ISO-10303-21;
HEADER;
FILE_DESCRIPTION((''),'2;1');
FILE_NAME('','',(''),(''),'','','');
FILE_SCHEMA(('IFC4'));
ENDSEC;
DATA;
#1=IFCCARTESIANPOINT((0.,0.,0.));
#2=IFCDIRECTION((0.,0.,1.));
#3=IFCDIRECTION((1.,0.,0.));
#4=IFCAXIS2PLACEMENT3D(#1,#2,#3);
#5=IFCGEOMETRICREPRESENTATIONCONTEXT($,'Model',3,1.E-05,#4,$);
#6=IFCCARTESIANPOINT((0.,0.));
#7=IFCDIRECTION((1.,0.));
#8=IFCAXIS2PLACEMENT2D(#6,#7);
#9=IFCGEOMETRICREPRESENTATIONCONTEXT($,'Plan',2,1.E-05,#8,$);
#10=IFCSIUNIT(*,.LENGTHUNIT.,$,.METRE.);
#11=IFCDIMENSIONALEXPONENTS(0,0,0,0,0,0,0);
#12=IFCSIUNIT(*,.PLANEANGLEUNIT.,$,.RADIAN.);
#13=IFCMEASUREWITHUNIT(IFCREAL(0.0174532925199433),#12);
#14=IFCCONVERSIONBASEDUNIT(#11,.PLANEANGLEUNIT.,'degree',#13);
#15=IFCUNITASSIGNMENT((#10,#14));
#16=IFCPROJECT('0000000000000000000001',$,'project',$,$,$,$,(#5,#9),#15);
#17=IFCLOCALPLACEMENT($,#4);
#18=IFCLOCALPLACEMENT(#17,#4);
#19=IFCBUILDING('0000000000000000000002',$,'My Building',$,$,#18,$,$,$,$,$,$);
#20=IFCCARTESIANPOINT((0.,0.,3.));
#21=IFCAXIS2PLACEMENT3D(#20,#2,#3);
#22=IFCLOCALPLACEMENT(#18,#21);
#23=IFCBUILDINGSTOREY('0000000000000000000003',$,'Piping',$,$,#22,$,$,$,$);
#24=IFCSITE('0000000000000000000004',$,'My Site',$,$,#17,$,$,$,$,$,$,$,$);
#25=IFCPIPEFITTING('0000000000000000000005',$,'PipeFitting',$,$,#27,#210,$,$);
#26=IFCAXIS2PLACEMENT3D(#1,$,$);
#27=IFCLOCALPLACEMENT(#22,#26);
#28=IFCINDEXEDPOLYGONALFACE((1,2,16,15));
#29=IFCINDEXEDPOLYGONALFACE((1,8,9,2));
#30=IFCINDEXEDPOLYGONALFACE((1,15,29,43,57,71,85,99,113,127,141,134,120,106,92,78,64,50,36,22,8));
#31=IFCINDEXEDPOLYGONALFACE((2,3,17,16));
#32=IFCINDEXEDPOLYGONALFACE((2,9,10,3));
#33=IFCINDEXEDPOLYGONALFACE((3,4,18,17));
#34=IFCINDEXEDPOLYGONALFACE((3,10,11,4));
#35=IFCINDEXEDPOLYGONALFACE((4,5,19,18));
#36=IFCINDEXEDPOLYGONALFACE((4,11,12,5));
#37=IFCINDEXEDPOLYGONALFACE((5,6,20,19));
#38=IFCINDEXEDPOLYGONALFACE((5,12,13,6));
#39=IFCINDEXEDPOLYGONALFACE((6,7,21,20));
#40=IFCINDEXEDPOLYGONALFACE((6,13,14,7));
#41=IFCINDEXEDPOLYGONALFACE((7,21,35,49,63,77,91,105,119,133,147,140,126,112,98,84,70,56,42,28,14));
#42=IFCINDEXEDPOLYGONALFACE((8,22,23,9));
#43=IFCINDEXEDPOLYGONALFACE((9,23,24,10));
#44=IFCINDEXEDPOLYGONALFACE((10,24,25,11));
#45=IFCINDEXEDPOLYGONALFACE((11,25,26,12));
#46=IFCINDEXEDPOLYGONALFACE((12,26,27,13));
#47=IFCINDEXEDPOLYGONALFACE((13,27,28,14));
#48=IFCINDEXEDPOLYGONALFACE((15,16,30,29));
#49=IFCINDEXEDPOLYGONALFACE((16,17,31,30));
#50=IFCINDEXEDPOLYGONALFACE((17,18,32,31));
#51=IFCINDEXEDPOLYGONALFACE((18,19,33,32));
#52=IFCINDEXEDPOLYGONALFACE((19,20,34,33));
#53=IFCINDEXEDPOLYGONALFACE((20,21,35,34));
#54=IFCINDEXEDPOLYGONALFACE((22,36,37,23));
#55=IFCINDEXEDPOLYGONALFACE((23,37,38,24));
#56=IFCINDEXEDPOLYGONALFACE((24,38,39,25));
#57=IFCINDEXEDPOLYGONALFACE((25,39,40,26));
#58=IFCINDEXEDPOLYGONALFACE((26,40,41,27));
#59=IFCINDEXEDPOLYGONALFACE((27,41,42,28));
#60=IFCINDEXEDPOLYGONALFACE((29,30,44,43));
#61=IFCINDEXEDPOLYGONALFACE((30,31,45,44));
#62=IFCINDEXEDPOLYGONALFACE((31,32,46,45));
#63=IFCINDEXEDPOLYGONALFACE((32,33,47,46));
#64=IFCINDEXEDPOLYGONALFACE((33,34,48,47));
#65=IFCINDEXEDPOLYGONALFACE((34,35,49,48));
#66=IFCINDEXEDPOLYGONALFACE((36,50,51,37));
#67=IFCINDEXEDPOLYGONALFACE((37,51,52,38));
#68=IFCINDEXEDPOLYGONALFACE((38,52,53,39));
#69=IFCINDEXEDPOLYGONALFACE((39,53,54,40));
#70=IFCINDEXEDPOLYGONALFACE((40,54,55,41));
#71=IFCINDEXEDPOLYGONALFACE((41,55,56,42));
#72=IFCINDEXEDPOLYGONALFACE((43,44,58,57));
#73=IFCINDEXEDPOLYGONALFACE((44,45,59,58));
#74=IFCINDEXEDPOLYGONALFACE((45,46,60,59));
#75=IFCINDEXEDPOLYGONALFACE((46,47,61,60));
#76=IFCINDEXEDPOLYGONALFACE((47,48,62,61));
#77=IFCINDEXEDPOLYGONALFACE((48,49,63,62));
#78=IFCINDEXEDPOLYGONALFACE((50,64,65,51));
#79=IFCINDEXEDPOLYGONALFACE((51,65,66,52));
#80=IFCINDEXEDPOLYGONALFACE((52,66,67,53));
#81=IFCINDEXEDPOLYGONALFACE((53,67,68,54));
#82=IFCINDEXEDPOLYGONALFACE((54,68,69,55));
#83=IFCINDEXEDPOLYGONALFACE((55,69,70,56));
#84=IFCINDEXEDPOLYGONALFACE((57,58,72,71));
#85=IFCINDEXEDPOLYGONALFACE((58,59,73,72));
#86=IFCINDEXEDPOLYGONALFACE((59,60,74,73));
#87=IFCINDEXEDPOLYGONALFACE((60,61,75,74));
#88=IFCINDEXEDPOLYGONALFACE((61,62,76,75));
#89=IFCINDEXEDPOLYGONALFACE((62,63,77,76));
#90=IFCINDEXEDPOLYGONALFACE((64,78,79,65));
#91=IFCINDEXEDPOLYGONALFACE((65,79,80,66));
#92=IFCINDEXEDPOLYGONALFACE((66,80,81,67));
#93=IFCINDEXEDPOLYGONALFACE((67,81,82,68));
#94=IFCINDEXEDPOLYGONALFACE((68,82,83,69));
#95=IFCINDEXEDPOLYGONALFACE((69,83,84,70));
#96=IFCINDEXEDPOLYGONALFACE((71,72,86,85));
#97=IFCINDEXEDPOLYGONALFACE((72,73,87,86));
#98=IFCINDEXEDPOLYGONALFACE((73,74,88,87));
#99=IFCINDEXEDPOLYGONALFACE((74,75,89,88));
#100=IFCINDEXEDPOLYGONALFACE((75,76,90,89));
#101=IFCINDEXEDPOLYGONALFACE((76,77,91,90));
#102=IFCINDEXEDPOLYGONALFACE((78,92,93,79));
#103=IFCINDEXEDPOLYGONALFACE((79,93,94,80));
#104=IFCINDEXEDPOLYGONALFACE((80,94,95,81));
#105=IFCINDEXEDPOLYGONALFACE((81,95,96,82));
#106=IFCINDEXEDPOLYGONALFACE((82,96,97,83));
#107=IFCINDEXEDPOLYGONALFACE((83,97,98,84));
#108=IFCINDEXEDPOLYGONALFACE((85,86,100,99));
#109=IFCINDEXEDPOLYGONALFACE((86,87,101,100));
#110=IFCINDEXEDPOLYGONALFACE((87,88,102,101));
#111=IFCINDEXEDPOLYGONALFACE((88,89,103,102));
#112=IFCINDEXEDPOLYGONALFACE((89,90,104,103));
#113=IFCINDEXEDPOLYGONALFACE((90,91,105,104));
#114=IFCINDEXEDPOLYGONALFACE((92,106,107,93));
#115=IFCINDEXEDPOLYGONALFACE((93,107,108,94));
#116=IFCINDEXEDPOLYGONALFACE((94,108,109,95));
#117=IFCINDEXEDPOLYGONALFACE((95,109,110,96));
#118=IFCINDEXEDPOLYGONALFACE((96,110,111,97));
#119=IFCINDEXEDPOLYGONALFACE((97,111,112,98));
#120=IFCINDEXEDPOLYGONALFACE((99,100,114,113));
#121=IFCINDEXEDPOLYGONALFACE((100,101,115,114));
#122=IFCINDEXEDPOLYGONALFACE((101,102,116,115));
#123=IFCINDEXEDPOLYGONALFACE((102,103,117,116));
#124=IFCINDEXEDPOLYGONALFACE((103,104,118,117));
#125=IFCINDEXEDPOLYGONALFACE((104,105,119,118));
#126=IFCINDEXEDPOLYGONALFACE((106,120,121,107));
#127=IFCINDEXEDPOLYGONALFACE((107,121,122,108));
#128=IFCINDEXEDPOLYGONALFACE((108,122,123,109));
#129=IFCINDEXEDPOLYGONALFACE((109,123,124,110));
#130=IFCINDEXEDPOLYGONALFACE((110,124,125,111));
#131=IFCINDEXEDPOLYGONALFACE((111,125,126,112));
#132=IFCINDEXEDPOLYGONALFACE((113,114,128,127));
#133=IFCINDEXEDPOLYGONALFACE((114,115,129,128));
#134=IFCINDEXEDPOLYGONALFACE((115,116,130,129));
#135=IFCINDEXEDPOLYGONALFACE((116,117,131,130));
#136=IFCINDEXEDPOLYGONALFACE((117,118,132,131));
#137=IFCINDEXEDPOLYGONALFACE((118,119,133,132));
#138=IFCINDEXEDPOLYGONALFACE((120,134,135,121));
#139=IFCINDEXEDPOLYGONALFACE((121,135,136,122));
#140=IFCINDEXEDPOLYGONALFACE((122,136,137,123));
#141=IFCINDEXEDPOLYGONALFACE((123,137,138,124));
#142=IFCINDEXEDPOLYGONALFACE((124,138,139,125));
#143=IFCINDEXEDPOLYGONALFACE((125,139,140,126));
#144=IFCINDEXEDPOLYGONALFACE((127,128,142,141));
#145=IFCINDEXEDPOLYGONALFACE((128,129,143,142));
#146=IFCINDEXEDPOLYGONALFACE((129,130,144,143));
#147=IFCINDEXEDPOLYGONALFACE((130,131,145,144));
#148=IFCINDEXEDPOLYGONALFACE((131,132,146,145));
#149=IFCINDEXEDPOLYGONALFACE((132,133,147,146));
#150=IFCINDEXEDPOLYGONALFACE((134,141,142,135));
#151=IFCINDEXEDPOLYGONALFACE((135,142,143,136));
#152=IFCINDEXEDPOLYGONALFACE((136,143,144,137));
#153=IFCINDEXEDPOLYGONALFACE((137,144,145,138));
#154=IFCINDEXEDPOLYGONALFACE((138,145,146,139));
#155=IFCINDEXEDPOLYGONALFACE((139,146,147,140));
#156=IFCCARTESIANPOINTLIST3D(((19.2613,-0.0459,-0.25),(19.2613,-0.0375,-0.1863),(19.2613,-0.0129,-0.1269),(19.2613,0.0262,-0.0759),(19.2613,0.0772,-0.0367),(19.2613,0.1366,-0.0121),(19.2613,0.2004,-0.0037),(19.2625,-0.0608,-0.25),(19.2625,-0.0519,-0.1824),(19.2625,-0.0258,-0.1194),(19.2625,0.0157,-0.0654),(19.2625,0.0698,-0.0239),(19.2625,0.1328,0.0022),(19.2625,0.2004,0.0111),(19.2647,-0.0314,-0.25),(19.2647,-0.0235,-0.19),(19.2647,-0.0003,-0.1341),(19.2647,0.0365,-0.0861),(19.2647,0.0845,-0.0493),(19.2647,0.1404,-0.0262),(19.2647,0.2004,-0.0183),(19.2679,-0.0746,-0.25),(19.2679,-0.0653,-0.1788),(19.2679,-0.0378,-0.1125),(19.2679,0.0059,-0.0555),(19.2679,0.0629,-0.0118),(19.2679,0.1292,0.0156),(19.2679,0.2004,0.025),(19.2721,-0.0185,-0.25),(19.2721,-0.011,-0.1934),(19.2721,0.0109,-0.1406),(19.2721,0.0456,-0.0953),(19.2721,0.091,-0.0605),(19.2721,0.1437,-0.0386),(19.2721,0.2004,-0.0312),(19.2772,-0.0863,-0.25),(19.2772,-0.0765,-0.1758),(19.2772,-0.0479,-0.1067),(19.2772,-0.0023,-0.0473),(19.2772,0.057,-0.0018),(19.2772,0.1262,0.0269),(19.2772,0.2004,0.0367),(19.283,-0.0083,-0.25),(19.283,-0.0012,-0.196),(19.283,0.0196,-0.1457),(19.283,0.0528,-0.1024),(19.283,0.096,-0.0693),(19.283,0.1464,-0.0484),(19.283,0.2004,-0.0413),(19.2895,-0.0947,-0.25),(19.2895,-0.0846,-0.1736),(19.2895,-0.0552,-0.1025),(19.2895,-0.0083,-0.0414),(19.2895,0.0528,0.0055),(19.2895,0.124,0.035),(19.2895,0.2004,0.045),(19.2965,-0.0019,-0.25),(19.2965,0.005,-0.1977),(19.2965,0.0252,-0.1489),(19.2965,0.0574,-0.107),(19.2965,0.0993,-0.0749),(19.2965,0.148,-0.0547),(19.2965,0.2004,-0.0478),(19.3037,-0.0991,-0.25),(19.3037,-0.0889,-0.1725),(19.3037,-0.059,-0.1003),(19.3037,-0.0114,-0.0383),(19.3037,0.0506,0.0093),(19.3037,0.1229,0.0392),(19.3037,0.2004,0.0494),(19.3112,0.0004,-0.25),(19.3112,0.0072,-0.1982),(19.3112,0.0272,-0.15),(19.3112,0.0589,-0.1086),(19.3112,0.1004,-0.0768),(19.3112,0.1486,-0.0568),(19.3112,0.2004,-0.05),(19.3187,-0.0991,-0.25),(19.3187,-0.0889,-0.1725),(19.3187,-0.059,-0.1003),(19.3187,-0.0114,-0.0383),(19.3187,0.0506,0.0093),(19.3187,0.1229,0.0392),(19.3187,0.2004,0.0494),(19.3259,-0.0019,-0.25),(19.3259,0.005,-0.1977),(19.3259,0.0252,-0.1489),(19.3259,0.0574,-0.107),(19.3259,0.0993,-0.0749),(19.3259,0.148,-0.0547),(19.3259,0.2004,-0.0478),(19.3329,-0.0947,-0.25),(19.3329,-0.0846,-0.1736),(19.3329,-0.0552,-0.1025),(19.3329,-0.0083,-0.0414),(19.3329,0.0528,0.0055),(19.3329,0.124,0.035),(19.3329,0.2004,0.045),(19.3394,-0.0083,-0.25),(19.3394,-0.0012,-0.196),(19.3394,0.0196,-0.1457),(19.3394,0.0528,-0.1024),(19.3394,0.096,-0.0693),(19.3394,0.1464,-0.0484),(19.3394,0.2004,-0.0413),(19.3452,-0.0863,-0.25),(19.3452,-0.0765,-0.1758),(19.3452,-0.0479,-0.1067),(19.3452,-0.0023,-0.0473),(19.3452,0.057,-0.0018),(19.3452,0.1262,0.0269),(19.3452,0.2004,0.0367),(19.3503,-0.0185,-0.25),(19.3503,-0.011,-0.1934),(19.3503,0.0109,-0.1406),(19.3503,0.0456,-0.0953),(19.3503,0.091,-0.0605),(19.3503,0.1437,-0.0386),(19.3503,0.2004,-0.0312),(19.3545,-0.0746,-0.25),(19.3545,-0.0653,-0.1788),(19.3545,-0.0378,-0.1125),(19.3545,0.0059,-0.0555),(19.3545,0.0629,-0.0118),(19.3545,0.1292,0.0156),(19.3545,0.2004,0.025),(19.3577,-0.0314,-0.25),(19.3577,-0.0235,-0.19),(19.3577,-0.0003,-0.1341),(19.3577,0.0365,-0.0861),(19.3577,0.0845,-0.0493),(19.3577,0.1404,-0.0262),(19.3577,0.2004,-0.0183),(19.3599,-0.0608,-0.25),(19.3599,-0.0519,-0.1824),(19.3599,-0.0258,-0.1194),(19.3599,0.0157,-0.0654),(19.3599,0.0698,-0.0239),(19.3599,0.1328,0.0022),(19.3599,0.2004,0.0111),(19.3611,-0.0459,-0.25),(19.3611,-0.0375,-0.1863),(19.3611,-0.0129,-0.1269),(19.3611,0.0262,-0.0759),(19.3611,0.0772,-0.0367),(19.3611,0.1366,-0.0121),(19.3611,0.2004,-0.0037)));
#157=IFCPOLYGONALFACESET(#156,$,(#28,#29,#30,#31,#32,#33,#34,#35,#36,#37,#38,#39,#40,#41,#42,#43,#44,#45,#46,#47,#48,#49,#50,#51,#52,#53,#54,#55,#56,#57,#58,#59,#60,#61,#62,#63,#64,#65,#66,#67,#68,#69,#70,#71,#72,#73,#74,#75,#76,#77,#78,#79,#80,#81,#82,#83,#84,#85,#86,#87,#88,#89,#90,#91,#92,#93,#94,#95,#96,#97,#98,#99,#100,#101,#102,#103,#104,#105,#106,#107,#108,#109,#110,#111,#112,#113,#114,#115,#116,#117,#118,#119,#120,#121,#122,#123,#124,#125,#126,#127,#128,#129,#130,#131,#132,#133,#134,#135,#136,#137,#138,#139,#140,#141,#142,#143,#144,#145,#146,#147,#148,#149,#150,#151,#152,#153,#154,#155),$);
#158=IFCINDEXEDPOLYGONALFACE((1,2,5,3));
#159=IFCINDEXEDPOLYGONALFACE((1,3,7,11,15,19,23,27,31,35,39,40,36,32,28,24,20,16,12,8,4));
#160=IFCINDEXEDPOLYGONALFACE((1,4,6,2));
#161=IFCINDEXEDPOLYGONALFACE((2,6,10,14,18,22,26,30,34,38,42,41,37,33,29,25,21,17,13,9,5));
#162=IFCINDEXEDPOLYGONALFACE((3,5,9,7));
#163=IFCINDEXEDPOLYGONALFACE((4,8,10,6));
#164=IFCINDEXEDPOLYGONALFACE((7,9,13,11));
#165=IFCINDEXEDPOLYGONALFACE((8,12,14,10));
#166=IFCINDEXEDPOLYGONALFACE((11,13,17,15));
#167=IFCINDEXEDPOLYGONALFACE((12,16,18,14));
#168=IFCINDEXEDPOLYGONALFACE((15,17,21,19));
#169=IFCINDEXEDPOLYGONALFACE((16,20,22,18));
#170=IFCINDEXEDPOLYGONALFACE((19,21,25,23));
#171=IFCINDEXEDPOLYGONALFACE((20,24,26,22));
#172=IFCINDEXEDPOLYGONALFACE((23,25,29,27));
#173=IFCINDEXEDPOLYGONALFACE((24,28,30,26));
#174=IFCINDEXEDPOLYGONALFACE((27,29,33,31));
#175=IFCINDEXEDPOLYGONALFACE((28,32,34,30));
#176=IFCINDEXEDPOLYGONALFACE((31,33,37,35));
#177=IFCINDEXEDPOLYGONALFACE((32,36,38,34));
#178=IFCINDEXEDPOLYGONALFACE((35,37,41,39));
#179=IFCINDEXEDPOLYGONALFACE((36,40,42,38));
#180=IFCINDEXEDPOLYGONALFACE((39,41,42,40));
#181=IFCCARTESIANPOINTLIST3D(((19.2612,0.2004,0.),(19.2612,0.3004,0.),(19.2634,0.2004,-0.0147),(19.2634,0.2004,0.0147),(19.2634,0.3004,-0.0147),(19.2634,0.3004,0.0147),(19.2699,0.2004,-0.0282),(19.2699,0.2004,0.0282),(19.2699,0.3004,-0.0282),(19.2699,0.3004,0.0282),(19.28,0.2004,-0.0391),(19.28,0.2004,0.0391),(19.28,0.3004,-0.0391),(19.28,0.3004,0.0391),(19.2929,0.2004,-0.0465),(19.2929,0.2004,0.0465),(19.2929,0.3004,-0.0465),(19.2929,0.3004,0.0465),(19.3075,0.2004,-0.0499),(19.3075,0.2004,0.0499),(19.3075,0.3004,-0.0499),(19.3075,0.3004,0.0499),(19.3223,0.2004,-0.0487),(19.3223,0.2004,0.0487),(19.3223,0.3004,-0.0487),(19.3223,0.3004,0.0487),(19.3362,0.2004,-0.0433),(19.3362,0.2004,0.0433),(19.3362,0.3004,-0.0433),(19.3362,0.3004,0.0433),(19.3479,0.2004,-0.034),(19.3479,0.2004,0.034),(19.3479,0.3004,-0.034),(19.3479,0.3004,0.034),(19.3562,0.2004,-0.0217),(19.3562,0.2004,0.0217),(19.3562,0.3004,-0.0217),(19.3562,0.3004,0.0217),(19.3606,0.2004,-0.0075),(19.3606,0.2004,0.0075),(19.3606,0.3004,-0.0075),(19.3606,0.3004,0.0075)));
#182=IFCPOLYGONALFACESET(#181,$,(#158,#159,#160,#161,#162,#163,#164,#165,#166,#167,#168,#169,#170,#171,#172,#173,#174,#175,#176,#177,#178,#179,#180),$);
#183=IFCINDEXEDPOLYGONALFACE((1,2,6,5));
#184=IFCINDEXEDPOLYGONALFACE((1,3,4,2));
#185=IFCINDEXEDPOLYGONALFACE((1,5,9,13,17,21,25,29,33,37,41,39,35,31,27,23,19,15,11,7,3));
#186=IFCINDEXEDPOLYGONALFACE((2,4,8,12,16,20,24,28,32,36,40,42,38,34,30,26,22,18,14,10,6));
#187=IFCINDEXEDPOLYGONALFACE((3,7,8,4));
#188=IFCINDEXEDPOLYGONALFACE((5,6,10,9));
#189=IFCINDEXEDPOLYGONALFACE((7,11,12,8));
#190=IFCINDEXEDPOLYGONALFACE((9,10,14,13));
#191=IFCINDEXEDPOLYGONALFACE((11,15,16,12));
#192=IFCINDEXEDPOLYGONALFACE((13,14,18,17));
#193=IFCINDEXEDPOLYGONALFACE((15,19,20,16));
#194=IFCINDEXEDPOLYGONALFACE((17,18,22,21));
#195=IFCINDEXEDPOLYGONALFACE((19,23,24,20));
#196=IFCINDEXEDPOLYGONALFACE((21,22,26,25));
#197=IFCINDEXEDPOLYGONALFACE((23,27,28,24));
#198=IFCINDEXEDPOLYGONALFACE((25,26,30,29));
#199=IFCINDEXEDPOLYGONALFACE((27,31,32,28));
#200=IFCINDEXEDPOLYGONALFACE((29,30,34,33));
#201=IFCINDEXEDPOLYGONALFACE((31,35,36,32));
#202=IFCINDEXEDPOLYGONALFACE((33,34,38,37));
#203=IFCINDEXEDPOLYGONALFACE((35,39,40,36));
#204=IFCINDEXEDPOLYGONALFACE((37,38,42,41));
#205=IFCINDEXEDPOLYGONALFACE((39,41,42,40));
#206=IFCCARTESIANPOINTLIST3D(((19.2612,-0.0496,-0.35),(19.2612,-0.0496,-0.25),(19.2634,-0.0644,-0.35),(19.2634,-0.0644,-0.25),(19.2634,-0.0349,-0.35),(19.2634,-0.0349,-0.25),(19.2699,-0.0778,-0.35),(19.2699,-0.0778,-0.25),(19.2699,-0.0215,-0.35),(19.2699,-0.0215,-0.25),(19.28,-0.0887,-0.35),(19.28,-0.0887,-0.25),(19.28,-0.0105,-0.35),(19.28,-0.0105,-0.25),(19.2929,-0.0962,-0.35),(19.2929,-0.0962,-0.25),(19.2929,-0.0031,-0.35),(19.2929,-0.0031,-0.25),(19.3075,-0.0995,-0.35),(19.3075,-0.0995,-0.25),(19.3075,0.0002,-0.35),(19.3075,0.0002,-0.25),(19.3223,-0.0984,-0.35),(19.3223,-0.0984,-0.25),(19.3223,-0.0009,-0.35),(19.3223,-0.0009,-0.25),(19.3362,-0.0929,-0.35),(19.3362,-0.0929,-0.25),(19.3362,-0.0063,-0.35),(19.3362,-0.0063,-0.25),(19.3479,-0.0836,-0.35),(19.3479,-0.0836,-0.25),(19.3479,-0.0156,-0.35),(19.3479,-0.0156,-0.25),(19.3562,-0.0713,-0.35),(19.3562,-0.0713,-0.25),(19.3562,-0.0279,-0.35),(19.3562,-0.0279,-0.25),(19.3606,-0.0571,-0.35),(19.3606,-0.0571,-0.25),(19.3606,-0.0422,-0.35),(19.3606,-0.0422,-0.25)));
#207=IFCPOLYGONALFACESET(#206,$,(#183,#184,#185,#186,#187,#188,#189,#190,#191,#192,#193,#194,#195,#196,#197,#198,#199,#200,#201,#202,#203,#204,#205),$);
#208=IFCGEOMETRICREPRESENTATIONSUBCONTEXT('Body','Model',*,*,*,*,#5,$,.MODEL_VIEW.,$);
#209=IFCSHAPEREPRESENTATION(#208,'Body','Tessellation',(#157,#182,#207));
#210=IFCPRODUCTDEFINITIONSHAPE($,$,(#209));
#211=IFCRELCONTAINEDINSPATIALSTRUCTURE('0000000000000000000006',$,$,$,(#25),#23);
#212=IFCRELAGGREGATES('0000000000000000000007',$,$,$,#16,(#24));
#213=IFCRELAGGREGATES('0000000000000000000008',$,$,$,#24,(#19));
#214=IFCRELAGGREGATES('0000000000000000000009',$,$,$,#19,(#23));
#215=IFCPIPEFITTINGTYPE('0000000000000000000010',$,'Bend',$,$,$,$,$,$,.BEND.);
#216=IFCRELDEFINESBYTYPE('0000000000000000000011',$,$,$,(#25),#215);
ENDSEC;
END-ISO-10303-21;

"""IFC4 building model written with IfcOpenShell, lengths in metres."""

from ifc_helpers import new_model, entity, si_unit, converted_unit, frame, origin_with_axes, origin_2d_with_axis, place, context, subcontext, project, spatial, circle, extrude, source, transform, mapped, type_object, type_shapes, element, save


model = new_model("IFC4")

# Units and contexts
model_context = context("Model", 3, precision=1e-05, world=origin_with_axes())
plan_context = context("Plan", 2, precision=1e-05, world=origin_2d_with_axis())
body_context = subcontext(model_context, "Body", "Model", "MODEL_VIEW")
ifc_project = project(units=[si_unit("LENGTHUNIT", "METRE"), converted_unit("PLANEANGLEUNIT", "degree", entity("IfcReal", 0.0174532925199433), si_unit("PLANEANGLEUNIT", "RADIAN"), dimensions=[0, 0, 0, 0, 0, 0, 0])], contexts=[model_context, plan_context])

# Site, building, storey
site_placement = place(None, origin_with_axes())
site = spatial("IfcSite", under=ifc_project, at=site_placement, Name="My Site")
building_placement = place(site_placement, origin_with_axes())
building = spatial("IfcBuilding", under=site, at=building_placement, Name="My Building")
storey_placement = place(building_placement, frame((0.0, 0.0, 3.0), z_axis=(0.0, 0.0, 1.0), x_axis=(1.0, 0.0, 0.0)))
storey = spatial("IfcBuildingStorey", under=building, at=storey_placement, Name="Piping")

# Pipe fitting
pipe_fitting_type = type_object("IfcPipeFittingType", Name="Bend", PredefinedType="BEND")
shared_shape = source(origin_with_axes(), body_context, "Body", "SolidModel", [
    entity("IfcSweptDiskSolid", entity("IfcIndexedPolyCurve", entity("IfcCartesianPointList3D", [[0.0, 0.0, -0.1], [0.0, -0.0732, -0.2768], [0.0, -0.25, -0.35]]), [entity("IfcArcIndex", [1, 2, 3])]), 0.05),
    extrude(circle(Radius=0.05), origin_with_axes(), (0.0, 0.0, -1.0), 0.1),
    extrude(circle(Radius=0.05), frame((0.0, -0.25, -0.35), z_axis=(0.0, -1.0, 0.0), x_axis=(1.0, 0.0, 0.0)), (0.0, 0.0, 1.0), 0.1),
])
type_shapes(pipe_fitting_type, [shared_shape])
for number, where, z_axis, x_axis, name in (
    (1, (19.3112, 0.3004, 0.0), (0.0, 1.0, 0.0), (-1.0, 0.0, 0.0), "PipeFitting"),
):
    element("IfcPipeFitting", number, at=place(storey_placement, frame(where, z_axis=z_axis, x_axis=x_axis)), inside=storey, type_object=pipe_fitting_type, Name=name, context=body_context, shape_type="MappedRepresentation", body=[
        mapped(shared_shape, transform((0.0, 0.0, 0.0), x_axis=(1.0, 0.0, 0.0), y_axis=(0.0, 1.0, 0.0), z_axis=(0.0, 0.0, 1.0), scale=1.0)),
    ])

save(model, "model.ifc")
